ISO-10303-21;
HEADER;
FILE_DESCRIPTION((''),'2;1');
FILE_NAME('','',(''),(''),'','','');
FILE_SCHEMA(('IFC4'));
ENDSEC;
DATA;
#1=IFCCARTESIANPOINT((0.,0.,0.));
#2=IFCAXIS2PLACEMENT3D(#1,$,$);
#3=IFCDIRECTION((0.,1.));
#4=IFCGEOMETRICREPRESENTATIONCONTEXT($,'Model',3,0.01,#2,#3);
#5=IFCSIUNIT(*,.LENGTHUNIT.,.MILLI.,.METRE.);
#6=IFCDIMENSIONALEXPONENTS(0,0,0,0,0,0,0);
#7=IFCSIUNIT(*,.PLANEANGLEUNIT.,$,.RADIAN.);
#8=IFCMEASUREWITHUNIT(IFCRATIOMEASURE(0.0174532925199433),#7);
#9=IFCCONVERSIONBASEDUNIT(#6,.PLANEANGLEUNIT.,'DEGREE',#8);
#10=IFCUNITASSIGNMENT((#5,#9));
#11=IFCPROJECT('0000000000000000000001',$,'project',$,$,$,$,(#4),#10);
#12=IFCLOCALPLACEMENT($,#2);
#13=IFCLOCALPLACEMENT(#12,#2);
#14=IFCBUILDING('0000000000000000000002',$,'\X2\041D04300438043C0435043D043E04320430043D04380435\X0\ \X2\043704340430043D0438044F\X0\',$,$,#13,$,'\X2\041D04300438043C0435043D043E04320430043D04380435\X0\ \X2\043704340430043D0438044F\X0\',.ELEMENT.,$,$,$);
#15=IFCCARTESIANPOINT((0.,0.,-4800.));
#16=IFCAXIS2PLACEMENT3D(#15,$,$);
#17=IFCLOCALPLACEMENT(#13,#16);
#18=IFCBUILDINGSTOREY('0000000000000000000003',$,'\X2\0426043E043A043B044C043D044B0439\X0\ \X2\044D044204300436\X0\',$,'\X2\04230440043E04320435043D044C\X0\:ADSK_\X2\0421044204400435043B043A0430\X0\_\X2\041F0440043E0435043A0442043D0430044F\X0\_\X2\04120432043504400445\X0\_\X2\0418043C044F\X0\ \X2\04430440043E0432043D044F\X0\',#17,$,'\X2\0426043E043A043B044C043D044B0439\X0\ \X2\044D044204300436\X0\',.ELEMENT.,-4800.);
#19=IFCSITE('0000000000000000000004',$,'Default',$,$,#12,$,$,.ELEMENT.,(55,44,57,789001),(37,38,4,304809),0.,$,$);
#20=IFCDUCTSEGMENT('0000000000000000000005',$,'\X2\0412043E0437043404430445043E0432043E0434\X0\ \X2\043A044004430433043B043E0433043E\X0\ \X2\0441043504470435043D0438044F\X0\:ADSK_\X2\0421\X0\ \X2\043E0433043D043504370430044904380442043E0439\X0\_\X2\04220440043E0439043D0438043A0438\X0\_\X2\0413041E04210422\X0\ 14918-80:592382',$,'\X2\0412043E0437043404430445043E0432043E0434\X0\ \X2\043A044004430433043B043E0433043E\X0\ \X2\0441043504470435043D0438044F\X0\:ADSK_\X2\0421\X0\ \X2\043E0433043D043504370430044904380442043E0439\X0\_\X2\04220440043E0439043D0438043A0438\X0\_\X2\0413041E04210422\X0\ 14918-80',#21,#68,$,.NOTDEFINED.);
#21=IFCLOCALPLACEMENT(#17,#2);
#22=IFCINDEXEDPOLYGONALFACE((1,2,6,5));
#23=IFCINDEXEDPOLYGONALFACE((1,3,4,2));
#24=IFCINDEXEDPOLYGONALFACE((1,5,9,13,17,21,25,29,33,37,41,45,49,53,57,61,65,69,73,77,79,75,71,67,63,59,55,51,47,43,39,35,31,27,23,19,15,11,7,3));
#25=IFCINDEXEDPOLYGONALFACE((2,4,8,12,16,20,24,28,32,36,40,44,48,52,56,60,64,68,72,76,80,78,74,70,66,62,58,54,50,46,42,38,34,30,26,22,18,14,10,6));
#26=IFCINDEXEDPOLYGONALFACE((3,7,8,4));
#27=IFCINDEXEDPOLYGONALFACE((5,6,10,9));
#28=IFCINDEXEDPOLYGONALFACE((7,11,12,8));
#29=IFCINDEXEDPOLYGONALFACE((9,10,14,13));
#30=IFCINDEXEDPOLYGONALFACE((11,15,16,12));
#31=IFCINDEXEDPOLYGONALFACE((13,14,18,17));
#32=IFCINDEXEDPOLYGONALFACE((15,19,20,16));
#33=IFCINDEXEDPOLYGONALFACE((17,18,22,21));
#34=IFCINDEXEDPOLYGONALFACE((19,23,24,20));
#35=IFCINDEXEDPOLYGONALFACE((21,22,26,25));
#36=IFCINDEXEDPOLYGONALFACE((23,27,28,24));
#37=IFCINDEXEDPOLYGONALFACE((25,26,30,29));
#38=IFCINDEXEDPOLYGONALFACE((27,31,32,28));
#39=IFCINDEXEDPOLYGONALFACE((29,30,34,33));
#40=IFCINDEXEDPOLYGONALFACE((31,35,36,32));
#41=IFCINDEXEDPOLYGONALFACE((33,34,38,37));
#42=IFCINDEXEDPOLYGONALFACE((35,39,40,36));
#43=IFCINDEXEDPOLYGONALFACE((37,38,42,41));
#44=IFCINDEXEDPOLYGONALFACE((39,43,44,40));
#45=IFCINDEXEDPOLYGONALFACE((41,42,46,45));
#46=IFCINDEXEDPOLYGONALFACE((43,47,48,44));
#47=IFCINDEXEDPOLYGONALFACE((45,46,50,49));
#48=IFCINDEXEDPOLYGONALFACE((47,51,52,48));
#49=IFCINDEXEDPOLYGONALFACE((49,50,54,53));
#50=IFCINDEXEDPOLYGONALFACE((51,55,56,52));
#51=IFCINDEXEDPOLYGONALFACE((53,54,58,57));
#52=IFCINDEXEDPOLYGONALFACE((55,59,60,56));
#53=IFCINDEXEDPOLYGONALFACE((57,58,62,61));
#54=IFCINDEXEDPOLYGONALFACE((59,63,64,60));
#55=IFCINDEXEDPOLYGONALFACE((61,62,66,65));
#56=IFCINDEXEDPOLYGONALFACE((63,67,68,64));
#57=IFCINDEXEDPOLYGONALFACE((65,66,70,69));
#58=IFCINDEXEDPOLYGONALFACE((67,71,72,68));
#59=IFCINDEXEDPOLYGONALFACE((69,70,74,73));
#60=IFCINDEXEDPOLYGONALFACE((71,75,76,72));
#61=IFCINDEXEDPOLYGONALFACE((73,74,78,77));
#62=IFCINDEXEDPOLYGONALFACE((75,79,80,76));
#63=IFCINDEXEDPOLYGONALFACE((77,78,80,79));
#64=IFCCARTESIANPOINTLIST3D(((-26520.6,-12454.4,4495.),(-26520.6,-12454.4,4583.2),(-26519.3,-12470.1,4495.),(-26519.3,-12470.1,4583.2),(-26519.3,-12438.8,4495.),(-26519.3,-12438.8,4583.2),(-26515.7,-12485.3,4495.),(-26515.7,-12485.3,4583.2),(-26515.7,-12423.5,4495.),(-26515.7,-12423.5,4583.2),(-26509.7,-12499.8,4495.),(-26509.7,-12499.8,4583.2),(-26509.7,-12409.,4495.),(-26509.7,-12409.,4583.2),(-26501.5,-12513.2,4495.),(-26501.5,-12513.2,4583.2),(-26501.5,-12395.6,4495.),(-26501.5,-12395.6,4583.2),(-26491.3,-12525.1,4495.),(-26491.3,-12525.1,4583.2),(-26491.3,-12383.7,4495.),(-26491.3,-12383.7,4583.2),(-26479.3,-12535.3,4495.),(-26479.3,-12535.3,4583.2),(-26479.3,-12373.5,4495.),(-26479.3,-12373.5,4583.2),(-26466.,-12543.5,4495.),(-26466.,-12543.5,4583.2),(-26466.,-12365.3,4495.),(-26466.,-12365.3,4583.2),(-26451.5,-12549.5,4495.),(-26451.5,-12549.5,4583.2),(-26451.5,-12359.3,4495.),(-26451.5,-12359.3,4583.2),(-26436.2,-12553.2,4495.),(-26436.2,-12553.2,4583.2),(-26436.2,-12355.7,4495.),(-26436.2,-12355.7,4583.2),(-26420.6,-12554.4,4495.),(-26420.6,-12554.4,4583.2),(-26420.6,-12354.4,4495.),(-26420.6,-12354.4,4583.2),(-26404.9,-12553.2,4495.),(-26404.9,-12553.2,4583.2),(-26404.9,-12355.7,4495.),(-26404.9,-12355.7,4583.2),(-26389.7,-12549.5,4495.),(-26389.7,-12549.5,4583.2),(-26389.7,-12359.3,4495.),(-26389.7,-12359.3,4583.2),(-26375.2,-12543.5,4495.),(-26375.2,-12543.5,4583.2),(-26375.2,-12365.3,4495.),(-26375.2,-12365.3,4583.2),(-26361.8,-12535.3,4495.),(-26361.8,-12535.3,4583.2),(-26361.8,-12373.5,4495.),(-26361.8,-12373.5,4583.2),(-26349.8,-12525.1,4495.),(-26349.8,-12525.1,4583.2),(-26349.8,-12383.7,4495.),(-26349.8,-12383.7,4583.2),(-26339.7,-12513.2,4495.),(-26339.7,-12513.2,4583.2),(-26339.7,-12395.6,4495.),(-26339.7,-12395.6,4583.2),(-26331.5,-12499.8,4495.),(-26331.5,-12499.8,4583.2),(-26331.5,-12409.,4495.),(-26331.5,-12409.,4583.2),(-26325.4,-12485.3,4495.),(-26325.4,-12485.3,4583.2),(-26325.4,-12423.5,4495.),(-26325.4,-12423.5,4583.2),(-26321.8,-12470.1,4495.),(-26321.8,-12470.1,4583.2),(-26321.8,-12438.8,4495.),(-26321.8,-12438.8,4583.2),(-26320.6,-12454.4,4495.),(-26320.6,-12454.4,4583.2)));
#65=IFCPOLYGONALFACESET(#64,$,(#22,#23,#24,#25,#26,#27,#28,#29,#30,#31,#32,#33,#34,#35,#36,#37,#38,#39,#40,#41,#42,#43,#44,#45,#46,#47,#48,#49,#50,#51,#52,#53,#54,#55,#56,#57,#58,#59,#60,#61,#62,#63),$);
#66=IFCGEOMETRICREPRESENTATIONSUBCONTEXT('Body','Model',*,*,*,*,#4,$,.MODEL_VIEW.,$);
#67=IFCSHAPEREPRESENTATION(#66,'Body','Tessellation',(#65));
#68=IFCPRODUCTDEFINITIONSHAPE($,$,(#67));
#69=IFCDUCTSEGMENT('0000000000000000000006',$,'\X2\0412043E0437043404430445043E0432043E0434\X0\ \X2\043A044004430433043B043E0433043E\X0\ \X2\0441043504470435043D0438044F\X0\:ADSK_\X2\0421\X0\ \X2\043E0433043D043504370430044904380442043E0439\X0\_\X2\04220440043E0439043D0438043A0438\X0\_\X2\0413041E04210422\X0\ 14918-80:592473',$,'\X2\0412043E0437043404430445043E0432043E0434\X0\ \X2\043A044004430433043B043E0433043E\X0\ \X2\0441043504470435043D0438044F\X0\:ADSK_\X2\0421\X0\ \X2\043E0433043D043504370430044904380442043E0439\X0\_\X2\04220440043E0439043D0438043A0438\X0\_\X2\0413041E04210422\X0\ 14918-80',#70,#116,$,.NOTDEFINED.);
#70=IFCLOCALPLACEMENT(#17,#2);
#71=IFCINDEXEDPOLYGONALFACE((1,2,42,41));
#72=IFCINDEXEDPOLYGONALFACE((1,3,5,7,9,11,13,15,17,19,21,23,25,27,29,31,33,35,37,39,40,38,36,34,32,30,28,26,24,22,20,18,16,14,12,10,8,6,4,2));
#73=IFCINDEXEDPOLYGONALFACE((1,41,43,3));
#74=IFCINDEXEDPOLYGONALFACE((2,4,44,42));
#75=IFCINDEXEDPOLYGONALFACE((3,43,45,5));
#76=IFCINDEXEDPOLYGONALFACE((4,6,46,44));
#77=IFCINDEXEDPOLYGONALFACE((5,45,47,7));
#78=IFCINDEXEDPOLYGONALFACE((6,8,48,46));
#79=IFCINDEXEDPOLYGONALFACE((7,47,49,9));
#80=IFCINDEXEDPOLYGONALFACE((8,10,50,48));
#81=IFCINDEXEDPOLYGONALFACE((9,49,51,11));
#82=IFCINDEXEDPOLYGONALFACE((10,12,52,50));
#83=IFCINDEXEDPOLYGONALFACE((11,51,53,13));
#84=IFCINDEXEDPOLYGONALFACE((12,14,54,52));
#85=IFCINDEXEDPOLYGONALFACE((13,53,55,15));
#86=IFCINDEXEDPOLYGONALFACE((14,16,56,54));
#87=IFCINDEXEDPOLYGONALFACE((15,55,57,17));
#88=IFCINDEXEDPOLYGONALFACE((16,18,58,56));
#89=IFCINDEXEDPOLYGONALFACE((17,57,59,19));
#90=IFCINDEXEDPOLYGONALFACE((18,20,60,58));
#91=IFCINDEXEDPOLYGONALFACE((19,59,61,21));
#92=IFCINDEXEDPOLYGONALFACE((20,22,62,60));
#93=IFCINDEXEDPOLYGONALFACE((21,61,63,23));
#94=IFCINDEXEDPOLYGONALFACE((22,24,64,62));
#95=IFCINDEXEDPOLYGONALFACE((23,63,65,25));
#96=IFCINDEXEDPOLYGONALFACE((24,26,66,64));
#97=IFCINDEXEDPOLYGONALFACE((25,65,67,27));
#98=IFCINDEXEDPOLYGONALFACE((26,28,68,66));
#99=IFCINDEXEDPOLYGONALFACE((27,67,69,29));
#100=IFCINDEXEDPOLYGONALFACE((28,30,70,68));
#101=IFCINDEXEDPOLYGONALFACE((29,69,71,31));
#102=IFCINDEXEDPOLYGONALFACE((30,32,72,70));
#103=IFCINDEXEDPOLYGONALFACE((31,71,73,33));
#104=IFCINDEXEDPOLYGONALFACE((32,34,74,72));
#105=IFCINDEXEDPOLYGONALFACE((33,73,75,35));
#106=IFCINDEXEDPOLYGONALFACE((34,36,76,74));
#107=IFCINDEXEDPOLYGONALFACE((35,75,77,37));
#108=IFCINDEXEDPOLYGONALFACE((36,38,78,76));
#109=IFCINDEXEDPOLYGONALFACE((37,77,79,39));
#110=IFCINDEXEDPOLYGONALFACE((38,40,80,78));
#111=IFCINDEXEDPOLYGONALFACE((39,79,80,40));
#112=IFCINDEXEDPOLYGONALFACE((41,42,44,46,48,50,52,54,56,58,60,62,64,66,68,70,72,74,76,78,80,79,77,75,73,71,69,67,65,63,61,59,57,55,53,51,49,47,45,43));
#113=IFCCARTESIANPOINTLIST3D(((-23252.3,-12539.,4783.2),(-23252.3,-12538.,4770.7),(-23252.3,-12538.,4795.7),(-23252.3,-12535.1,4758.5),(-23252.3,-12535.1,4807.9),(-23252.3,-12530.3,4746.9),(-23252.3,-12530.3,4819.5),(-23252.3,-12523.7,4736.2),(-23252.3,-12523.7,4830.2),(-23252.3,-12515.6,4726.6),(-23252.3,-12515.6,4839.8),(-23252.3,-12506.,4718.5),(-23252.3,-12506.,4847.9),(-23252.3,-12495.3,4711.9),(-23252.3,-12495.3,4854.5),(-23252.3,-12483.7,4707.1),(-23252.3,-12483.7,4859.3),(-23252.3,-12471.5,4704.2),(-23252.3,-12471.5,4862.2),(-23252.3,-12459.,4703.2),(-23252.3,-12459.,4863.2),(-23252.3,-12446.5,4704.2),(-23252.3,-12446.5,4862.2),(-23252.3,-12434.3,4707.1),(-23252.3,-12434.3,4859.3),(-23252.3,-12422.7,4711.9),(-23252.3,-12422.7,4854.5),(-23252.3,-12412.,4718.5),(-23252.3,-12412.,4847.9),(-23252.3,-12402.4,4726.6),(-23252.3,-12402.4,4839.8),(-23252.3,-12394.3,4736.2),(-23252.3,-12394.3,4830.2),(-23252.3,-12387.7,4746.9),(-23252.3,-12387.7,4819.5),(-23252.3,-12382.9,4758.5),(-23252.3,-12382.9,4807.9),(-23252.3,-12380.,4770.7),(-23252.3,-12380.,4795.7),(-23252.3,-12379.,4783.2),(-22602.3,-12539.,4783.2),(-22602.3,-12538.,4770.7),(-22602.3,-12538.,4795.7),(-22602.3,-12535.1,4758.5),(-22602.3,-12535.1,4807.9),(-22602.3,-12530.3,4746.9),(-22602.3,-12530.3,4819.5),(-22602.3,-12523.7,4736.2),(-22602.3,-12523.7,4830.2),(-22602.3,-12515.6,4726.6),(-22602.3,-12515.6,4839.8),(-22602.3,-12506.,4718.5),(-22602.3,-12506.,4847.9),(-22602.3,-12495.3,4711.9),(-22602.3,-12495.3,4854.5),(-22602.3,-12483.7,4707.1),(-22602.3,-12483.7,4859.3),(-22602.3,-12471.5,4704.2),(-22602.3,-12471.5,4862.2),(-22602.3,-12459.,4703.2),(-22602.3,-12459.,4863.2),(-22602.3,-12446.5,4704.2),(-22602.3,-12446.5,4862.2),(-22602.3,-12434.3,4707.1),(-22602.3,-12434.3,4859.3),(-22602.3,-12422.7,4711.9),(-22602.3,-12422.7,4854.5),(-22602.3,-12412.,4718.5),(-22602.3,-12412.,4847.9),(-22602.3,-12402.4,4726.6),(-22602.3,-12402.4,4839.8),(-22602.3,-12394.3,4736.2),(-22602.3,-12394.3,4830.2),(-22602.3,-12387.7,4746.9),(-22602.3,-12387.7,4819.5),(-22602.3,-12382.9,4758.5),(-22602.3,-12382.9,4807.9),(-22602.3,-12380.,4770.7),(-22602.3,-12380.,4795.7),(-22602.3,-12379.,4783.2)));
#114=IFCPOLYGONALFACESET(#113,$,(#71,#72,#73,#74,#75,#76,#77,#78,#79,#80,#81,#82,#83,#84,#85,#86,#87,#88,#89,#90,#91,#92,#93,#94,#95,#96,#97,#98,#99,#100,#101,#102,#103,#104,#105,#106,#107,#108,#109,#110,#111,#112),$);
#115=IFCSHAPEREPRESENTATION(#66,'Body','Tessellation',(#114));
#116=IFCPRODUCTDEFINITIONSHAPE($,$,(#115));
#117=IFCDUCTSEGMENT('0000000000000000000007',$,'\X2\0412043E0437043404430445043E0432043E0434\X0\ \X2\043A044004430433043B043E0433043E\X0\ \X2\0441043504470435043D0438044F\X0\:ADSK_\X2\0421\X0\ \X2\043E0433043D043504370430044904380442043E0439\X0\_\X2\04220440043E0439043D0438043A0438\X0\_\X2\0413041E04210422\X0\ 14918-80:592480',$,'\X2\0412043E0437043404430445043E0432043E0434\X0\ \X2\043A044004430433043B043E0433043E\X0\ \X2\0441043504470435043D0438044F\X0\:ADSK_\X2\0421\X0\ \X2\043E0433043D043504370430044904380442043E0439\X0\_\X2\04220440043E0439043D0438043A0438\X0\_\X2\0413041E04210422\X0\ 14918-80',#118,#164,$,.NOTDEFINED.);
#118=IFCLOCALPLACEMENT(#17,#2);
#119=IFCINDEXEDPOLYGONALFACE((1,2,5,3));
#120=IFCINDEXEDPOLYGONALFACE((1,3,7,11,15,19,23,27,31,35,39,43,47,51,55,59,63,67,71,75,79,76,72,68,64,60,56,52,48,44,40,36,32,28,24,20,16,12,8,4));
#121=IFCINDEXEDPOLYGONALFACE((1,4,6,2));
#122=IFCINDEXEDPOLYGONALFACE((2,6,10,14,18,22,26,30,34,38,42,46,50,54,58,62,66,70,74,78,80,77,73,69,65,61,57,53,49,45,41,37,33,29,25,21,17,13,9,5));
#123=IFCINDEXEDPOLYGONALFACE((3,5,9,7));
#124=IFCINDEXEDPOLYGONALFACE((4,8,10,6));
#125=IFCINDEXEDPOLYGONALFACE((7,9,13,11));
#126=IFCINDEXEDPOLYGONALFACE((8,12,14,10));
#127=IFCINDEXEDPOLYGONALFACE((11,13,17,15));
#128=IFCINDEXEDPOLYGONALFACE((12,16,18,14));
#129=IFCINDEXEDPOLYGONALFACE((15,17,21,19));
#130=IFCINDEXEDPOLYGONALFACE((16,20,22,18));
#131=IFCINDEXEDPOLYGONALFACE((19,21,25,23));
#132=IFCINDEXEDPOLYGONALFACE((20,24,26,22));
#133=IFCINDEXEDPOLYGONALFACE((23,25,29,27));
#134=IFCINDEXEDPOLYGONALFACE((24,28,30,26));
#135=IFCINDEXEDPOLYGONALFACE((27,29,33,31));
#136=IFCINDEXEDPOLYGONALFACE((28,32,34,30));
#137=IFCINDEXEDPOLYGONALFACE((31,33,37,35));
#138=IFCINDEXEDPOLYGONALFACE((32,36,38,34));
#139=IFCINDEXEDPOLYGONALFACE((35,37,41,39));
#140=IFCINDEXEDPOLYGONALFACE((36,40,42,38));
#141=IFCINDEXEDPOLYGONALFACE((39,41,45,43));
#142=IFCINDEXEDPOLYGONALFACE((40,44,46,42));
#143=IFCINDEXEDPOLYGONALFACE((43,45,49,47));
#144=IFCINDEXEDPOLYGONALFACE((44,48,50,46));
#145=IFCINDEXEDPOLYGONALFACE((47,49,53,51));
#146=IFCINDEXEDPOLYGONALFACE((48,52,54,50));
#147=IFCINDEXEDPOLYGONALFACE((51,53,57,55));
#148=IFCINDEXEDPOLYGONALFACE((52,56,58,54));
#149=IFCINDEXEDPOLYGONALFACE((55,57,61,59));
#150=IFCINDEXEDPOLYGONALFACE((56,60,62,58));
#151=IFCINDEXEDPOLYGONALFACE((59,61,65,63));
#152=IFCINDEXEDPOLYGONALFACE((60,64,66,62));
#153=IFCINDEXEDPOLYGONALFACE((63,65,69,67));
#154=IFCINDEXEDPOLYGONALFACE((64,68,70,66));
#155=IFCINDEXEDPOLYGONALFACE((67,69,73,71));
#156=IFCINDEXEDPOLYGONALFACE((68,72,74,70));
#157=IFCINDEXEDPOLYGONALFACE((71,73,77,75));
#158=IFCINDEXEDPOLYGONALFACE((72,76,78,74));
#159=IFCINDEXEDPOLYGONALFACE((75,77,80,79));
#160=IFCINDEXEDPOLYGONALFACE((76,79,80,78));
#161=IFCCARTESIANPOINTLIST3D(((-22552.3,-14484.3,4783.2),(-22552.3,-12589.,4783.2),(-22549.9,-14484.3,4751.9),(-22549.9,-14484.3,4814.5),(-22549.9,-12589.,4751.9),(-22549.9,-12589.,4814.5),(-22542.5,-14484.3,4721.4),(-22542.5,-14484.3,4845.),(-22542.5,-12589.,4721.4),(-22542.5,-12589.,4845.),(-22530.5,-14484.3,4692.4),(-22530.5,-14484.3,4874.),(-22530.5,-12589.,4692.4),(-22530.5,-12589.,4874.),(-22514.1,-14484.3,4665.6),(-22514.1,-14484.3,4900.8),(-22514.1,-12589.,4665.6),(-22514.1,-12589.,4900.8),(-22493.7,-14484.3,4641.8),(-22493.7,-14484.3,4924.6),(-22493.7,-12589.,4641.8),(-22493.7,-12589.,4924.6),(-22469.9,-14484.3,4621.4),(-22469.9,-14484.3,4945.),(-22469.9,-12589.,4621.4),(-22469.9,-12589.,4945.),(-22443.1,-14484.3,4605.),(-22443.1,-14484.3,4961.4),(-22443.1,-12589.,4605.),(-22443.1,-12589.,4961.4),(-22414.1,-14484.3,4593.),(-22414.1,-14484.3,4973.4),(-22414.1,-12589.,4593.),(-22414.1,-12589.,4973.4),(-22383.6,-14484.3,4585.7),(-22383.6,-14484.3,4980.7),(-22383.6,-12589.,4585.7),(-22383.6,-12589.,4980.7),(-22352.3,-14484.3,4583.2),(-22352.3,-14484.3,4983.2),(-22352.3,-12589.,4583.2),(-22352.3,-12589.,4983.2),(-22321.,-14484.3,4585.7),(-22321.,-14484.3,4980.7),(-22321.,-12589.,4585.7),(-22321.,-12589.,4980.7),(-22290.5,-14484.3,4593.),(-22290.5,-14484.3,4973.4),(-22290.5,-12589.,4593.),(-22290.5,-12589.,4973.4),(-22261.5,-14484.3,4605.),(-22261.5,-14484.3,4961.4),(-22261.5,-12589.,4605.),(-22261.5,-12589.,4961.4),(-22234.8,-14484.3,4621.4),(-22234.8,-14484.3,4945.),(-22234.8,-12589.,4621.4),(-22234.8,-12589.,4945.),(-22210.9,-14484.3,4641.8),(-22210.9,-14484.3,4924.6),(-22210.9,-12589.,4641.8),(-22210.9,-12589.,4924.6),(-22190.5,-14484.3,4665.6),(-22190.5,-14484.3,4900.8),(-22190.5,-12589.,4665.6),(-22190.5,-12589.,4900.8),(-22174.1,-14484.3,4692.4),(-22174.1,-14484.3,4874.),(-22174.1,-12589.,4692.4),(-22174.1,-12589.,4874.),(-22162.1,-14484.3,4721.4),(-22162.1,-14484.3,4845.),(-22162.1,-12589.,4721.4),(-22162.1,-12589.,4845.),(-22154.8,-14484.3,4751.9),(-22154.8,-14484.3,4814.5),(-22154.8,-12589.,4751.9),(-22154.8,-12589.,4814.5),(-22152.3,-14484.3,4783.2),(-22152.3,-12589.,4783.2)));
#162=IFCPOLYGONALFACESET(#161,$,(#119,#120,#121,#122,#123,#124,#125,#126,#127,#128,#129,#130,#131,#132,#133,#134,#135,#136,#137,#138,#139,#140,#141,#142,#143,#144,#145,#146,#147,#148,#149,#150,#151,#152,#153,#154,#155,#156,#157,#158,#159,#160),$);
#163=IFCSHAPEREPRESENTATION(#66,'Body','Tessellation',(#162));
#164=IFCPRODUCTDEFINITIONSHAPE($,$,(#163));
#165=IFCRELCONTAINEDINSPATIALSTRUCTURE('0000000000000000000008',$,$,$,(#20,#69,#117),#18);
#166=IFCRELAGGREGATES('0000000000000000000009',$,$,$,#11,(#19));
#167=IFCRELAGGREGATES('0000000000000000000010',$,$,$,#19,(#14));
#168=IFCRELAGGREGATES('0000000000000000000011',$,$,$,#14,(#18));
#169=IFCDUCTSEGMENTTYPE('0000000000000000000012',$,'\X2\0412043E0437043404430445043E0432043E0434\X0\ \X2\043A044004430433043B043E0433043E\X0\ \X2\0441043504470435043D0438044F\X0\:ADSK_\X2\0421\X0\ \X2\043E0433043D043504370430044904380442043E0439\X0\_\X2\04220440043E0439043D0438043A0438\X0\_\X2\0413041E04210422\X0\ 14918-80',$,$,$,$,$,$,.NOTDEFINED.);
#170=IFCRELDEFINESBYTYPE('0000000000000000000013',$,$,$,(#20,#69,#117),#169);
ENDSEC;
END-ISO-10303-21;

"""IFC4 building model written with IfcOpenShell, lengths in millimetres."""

from ifc_helpers import new_model, entity, si_unit, converted_unit, direction, frame, origin, place, context, subcontext, project, spatial, indexed_curve, outline, extrude, type_object, element, save


model = new_model("IFC4")

# Units and contexts
model_context = context("Model", 3, precision=0.01, world=origin(), true_north=direction((0.0, 1.0)))
body_context = subcontext(model_context, "Body", "Model", "MODEL_VIEW")
ifc_project = project(units=[si_unit("LENGTHUNIT", "METRE", prefix="MILLI"), converted_unit("PLANEANGLEUNIT", "DEGREE", entity("IfcRatioMeasure", 0.0174532925199433), si_unit("PLANEANGLEUNIT", "RADIAN"), dimensions=[0, 0, 0, 0, 0, 0, 0])], contexts=[model_context])

# Site, building, storey
site_placement = place(None, origin())
site = spatial("IfcSite", under=ifc_project, at=site_placement, Name="Default", CompositionType="ELEMENT", RefLatitude=(55, 44, 57, 789001), RefLongitude=(37, 38, 4, 304809), RefElevation=0.0)
building_placement = place(site_placement, origin())
building = spatial("IfcBuilding", under=site, at=building_placement, Name="Наименование здания", LongName="Наименование здания", CompositionType="ELEMENT")
storey_placement = place(building_placement, frame((0.0, 0.0, -4800.0)))
storey = spatial("IfcBuildingStorey", under=building, at=storey_placement, Name="Цокльный этаж", ObjectType="Уровень:ADSK_Стрелка_Проектная_Вверх_Имя уровня", LongName="Цокльный этаж", CompositionType="ELEMENT", Elevation=-4800.0)

# Duct segments
duct_segment_type = type_object("IfcDuctSegmentType", Name="Воздуховод круглого сечения:ADSK_С огнезащитой_Тройники_ГОСТ 14918-80", PredefinedType="NOTDEFINED")
duct_segment_1_placement = place(storey_placement, origin())
element("IfcDuctSegment", 1, at=duct_segment_1_placement, inside=storey, type_object=duct_segment_type, Name="Воздуховод круглого сечения:ADSK_С огнезащитой_Тройники_ГОСТ 14918-80:592382", ObjectType="Воздуховод круглого сечения:ADSK_С огнезащитой_Тройники_ГОСТ 14918-80", PredefinedType="NOTDEFINED", context=body_context, shape_type="SweptSolid", body=[
    extrude(outline(indexed_curve([(100.0, 0.0), (98.8, 15.6), (95.1, 30.9), (89.1, 45.4), (80.9, 58.8), (70.7, 70.7), (58.8, 80.9), (45.4, 89.1), (30.9, 95.1), (15.6, 98.8), (0.0, 100.0), (-15.6, 98.8), (-30.9, 95.1), (-45.4, 89.1), (-58.8, 80.9), (-70.7, 70.7), (-80.9, 58.8), (-89.1, 45.4), (-95.1, 30.9), (-98.8, 15.6), (-100.0, 0.0), (-98.8, -15.6), (-95.1, -30.9), (-89.1, -45.4), (-80.9, -58.8), (-70.7, -70.7), (-58.8, -80.9), (-45.4, -89.1), (-30.9, -95.1), (-15.6, -98.8), (0.0, -100.0), (15.6, -98.8), (30.9, -95.1), (45.4, -89.1), (58.8, -80.9), (70.7, -70.7), (80.9, -58.8), (89.1, -45.4), (95.1, -30.9), (98.8, -15.6), (100.0, 0.0)], self_intersect=False)), frame((-26420.6, -12454.4, 4495.0)), (0.0, 0.0, 1.0), 88.2),
])
duct_segment_2_placement = place(storey_placement, origin())
element("IfcDuctSegment", 2, at=duct_segment_2_placement, inside=storey, type_object=duct_segment_type, Name="Воздуховод круглого сечения:ADSK_С огнезащитой_Тройники_ГОСТ 14918-80:592473", ObjectType="Воздуховод круглого сечения:ADSK_С огнезащитой_Тройники_ГОСТ 14918-80", PredefinedType="NOTDEFINED", context=body_context, shape_type="SweptSolid", body=[
    extrude(outline(indexed_curve([(80.0, 0.0), (79.0, 12.5), (76.1, 24.7), (71.3, 36.3), (64.7, 47.0), (56.6, 56.6), (47.0, 64.7), (36.3, 71.3), (24.7, 76.1), (12.5, 79.0), (0.0, 80.0), (-12.5, 79.0), (-24.7, 76.1), (-36.3, 71.3), (-47.0, 64.7), (-56.6, 56.6), (-64.7, 47.0), (-71.3, 36.3), (-76.1, 24.7), (-79.0, 12.5), (-80.0, 0.0), (-79.0, -12.5), (-76.1, -24.7), (-71.3, -36.3), (-64.7, -47.0), (-56.6, -56.6), (-47.0, -64.7), (-36.3, -71.3), (-24.7, -76.1), (-12.5, -79.0), (0.0, -80.0), (12.5, -79.0), (24.7, -76.1), (36.3, -71.3), (47.0, -64.7), (56.6, -56.6), (64.7, -47.0), (71.3, -36.3), (76.1, -24.7), (79.0, -12.5), (80.0, 0.0)], self_intersect=False)), frame((-23252.3, -12459.0, 4783.2), z_axis=(1.0, 0.0, 0.0), x_axis=(0.0, 1.0, 0.0)), (0.0, 0.0, 1.0), 650.0),
])
duct_segment_3_placement = place(storey_placement, origin())
element("IfcDuctSegment", 3, at=duct_segment_3_placement, inside=storey, type_object=duct_segment_type, Name="Воздуховод круглого сечения:ADSK_С огнезащитой_Тройники_ГОСТ 14918-80:592480", ObjectType="Воздуховод круглого сечения:ADSK_С огнезащитой_Тройники_ГОСТ 14918-80", PredefinedType="NOTDEFINED", context=body_context, shape_type="SweptSolid", body=[
    extrude(outline(indexed_curve([(200.0, 0.0), (197.5, 31.3), (190.2, 61.8), (178.2, 90.8), (161.8, 117.6), (141.4, 141.4), (117.6, 161.8), (90.8, 178.2), (61.8, 190.2), (31.3, 197.5), (0.0, 200.0), (-31.3, 197.5), (-61.8, 190.2), (-90.8, 178.2), (-117.6, 161.8), (-141.4, 141.4), (-161.8, 117.6), (-178.2, 90.8), (-190.2, 61.8), (-197.5, 31.3), (-200.0, 0.0), (-197.5, -31.3), (-190.2, -61.8), (-178.2, -90.8), (-161.8, -117.6), (-141.4, -141.4), (-117.6, -161.8), (-90.8, -178.2), (-61.8, -190.2), (-31.3, -197.5), (0.0, -200.0), (31.3, -197.5), (61.8, -190.2), (90.8, -178.2), (117.6, -161.8), (141.4, -141.4), (161.8, -117.6), (178.2, -90.8), (190.2, -61.8), (197.5, -31.3), (200.0, 0.0)], self_intersect=False)), frame((-22352.3, -14484.3, 4783.2), z_axis=(0.0, 1.0, 0.0), x_axis=(1.0, 0.0, 0.0)), (0.0, 0.0, 1.0), 1895.3),
])

save(model, "model.ifc")
